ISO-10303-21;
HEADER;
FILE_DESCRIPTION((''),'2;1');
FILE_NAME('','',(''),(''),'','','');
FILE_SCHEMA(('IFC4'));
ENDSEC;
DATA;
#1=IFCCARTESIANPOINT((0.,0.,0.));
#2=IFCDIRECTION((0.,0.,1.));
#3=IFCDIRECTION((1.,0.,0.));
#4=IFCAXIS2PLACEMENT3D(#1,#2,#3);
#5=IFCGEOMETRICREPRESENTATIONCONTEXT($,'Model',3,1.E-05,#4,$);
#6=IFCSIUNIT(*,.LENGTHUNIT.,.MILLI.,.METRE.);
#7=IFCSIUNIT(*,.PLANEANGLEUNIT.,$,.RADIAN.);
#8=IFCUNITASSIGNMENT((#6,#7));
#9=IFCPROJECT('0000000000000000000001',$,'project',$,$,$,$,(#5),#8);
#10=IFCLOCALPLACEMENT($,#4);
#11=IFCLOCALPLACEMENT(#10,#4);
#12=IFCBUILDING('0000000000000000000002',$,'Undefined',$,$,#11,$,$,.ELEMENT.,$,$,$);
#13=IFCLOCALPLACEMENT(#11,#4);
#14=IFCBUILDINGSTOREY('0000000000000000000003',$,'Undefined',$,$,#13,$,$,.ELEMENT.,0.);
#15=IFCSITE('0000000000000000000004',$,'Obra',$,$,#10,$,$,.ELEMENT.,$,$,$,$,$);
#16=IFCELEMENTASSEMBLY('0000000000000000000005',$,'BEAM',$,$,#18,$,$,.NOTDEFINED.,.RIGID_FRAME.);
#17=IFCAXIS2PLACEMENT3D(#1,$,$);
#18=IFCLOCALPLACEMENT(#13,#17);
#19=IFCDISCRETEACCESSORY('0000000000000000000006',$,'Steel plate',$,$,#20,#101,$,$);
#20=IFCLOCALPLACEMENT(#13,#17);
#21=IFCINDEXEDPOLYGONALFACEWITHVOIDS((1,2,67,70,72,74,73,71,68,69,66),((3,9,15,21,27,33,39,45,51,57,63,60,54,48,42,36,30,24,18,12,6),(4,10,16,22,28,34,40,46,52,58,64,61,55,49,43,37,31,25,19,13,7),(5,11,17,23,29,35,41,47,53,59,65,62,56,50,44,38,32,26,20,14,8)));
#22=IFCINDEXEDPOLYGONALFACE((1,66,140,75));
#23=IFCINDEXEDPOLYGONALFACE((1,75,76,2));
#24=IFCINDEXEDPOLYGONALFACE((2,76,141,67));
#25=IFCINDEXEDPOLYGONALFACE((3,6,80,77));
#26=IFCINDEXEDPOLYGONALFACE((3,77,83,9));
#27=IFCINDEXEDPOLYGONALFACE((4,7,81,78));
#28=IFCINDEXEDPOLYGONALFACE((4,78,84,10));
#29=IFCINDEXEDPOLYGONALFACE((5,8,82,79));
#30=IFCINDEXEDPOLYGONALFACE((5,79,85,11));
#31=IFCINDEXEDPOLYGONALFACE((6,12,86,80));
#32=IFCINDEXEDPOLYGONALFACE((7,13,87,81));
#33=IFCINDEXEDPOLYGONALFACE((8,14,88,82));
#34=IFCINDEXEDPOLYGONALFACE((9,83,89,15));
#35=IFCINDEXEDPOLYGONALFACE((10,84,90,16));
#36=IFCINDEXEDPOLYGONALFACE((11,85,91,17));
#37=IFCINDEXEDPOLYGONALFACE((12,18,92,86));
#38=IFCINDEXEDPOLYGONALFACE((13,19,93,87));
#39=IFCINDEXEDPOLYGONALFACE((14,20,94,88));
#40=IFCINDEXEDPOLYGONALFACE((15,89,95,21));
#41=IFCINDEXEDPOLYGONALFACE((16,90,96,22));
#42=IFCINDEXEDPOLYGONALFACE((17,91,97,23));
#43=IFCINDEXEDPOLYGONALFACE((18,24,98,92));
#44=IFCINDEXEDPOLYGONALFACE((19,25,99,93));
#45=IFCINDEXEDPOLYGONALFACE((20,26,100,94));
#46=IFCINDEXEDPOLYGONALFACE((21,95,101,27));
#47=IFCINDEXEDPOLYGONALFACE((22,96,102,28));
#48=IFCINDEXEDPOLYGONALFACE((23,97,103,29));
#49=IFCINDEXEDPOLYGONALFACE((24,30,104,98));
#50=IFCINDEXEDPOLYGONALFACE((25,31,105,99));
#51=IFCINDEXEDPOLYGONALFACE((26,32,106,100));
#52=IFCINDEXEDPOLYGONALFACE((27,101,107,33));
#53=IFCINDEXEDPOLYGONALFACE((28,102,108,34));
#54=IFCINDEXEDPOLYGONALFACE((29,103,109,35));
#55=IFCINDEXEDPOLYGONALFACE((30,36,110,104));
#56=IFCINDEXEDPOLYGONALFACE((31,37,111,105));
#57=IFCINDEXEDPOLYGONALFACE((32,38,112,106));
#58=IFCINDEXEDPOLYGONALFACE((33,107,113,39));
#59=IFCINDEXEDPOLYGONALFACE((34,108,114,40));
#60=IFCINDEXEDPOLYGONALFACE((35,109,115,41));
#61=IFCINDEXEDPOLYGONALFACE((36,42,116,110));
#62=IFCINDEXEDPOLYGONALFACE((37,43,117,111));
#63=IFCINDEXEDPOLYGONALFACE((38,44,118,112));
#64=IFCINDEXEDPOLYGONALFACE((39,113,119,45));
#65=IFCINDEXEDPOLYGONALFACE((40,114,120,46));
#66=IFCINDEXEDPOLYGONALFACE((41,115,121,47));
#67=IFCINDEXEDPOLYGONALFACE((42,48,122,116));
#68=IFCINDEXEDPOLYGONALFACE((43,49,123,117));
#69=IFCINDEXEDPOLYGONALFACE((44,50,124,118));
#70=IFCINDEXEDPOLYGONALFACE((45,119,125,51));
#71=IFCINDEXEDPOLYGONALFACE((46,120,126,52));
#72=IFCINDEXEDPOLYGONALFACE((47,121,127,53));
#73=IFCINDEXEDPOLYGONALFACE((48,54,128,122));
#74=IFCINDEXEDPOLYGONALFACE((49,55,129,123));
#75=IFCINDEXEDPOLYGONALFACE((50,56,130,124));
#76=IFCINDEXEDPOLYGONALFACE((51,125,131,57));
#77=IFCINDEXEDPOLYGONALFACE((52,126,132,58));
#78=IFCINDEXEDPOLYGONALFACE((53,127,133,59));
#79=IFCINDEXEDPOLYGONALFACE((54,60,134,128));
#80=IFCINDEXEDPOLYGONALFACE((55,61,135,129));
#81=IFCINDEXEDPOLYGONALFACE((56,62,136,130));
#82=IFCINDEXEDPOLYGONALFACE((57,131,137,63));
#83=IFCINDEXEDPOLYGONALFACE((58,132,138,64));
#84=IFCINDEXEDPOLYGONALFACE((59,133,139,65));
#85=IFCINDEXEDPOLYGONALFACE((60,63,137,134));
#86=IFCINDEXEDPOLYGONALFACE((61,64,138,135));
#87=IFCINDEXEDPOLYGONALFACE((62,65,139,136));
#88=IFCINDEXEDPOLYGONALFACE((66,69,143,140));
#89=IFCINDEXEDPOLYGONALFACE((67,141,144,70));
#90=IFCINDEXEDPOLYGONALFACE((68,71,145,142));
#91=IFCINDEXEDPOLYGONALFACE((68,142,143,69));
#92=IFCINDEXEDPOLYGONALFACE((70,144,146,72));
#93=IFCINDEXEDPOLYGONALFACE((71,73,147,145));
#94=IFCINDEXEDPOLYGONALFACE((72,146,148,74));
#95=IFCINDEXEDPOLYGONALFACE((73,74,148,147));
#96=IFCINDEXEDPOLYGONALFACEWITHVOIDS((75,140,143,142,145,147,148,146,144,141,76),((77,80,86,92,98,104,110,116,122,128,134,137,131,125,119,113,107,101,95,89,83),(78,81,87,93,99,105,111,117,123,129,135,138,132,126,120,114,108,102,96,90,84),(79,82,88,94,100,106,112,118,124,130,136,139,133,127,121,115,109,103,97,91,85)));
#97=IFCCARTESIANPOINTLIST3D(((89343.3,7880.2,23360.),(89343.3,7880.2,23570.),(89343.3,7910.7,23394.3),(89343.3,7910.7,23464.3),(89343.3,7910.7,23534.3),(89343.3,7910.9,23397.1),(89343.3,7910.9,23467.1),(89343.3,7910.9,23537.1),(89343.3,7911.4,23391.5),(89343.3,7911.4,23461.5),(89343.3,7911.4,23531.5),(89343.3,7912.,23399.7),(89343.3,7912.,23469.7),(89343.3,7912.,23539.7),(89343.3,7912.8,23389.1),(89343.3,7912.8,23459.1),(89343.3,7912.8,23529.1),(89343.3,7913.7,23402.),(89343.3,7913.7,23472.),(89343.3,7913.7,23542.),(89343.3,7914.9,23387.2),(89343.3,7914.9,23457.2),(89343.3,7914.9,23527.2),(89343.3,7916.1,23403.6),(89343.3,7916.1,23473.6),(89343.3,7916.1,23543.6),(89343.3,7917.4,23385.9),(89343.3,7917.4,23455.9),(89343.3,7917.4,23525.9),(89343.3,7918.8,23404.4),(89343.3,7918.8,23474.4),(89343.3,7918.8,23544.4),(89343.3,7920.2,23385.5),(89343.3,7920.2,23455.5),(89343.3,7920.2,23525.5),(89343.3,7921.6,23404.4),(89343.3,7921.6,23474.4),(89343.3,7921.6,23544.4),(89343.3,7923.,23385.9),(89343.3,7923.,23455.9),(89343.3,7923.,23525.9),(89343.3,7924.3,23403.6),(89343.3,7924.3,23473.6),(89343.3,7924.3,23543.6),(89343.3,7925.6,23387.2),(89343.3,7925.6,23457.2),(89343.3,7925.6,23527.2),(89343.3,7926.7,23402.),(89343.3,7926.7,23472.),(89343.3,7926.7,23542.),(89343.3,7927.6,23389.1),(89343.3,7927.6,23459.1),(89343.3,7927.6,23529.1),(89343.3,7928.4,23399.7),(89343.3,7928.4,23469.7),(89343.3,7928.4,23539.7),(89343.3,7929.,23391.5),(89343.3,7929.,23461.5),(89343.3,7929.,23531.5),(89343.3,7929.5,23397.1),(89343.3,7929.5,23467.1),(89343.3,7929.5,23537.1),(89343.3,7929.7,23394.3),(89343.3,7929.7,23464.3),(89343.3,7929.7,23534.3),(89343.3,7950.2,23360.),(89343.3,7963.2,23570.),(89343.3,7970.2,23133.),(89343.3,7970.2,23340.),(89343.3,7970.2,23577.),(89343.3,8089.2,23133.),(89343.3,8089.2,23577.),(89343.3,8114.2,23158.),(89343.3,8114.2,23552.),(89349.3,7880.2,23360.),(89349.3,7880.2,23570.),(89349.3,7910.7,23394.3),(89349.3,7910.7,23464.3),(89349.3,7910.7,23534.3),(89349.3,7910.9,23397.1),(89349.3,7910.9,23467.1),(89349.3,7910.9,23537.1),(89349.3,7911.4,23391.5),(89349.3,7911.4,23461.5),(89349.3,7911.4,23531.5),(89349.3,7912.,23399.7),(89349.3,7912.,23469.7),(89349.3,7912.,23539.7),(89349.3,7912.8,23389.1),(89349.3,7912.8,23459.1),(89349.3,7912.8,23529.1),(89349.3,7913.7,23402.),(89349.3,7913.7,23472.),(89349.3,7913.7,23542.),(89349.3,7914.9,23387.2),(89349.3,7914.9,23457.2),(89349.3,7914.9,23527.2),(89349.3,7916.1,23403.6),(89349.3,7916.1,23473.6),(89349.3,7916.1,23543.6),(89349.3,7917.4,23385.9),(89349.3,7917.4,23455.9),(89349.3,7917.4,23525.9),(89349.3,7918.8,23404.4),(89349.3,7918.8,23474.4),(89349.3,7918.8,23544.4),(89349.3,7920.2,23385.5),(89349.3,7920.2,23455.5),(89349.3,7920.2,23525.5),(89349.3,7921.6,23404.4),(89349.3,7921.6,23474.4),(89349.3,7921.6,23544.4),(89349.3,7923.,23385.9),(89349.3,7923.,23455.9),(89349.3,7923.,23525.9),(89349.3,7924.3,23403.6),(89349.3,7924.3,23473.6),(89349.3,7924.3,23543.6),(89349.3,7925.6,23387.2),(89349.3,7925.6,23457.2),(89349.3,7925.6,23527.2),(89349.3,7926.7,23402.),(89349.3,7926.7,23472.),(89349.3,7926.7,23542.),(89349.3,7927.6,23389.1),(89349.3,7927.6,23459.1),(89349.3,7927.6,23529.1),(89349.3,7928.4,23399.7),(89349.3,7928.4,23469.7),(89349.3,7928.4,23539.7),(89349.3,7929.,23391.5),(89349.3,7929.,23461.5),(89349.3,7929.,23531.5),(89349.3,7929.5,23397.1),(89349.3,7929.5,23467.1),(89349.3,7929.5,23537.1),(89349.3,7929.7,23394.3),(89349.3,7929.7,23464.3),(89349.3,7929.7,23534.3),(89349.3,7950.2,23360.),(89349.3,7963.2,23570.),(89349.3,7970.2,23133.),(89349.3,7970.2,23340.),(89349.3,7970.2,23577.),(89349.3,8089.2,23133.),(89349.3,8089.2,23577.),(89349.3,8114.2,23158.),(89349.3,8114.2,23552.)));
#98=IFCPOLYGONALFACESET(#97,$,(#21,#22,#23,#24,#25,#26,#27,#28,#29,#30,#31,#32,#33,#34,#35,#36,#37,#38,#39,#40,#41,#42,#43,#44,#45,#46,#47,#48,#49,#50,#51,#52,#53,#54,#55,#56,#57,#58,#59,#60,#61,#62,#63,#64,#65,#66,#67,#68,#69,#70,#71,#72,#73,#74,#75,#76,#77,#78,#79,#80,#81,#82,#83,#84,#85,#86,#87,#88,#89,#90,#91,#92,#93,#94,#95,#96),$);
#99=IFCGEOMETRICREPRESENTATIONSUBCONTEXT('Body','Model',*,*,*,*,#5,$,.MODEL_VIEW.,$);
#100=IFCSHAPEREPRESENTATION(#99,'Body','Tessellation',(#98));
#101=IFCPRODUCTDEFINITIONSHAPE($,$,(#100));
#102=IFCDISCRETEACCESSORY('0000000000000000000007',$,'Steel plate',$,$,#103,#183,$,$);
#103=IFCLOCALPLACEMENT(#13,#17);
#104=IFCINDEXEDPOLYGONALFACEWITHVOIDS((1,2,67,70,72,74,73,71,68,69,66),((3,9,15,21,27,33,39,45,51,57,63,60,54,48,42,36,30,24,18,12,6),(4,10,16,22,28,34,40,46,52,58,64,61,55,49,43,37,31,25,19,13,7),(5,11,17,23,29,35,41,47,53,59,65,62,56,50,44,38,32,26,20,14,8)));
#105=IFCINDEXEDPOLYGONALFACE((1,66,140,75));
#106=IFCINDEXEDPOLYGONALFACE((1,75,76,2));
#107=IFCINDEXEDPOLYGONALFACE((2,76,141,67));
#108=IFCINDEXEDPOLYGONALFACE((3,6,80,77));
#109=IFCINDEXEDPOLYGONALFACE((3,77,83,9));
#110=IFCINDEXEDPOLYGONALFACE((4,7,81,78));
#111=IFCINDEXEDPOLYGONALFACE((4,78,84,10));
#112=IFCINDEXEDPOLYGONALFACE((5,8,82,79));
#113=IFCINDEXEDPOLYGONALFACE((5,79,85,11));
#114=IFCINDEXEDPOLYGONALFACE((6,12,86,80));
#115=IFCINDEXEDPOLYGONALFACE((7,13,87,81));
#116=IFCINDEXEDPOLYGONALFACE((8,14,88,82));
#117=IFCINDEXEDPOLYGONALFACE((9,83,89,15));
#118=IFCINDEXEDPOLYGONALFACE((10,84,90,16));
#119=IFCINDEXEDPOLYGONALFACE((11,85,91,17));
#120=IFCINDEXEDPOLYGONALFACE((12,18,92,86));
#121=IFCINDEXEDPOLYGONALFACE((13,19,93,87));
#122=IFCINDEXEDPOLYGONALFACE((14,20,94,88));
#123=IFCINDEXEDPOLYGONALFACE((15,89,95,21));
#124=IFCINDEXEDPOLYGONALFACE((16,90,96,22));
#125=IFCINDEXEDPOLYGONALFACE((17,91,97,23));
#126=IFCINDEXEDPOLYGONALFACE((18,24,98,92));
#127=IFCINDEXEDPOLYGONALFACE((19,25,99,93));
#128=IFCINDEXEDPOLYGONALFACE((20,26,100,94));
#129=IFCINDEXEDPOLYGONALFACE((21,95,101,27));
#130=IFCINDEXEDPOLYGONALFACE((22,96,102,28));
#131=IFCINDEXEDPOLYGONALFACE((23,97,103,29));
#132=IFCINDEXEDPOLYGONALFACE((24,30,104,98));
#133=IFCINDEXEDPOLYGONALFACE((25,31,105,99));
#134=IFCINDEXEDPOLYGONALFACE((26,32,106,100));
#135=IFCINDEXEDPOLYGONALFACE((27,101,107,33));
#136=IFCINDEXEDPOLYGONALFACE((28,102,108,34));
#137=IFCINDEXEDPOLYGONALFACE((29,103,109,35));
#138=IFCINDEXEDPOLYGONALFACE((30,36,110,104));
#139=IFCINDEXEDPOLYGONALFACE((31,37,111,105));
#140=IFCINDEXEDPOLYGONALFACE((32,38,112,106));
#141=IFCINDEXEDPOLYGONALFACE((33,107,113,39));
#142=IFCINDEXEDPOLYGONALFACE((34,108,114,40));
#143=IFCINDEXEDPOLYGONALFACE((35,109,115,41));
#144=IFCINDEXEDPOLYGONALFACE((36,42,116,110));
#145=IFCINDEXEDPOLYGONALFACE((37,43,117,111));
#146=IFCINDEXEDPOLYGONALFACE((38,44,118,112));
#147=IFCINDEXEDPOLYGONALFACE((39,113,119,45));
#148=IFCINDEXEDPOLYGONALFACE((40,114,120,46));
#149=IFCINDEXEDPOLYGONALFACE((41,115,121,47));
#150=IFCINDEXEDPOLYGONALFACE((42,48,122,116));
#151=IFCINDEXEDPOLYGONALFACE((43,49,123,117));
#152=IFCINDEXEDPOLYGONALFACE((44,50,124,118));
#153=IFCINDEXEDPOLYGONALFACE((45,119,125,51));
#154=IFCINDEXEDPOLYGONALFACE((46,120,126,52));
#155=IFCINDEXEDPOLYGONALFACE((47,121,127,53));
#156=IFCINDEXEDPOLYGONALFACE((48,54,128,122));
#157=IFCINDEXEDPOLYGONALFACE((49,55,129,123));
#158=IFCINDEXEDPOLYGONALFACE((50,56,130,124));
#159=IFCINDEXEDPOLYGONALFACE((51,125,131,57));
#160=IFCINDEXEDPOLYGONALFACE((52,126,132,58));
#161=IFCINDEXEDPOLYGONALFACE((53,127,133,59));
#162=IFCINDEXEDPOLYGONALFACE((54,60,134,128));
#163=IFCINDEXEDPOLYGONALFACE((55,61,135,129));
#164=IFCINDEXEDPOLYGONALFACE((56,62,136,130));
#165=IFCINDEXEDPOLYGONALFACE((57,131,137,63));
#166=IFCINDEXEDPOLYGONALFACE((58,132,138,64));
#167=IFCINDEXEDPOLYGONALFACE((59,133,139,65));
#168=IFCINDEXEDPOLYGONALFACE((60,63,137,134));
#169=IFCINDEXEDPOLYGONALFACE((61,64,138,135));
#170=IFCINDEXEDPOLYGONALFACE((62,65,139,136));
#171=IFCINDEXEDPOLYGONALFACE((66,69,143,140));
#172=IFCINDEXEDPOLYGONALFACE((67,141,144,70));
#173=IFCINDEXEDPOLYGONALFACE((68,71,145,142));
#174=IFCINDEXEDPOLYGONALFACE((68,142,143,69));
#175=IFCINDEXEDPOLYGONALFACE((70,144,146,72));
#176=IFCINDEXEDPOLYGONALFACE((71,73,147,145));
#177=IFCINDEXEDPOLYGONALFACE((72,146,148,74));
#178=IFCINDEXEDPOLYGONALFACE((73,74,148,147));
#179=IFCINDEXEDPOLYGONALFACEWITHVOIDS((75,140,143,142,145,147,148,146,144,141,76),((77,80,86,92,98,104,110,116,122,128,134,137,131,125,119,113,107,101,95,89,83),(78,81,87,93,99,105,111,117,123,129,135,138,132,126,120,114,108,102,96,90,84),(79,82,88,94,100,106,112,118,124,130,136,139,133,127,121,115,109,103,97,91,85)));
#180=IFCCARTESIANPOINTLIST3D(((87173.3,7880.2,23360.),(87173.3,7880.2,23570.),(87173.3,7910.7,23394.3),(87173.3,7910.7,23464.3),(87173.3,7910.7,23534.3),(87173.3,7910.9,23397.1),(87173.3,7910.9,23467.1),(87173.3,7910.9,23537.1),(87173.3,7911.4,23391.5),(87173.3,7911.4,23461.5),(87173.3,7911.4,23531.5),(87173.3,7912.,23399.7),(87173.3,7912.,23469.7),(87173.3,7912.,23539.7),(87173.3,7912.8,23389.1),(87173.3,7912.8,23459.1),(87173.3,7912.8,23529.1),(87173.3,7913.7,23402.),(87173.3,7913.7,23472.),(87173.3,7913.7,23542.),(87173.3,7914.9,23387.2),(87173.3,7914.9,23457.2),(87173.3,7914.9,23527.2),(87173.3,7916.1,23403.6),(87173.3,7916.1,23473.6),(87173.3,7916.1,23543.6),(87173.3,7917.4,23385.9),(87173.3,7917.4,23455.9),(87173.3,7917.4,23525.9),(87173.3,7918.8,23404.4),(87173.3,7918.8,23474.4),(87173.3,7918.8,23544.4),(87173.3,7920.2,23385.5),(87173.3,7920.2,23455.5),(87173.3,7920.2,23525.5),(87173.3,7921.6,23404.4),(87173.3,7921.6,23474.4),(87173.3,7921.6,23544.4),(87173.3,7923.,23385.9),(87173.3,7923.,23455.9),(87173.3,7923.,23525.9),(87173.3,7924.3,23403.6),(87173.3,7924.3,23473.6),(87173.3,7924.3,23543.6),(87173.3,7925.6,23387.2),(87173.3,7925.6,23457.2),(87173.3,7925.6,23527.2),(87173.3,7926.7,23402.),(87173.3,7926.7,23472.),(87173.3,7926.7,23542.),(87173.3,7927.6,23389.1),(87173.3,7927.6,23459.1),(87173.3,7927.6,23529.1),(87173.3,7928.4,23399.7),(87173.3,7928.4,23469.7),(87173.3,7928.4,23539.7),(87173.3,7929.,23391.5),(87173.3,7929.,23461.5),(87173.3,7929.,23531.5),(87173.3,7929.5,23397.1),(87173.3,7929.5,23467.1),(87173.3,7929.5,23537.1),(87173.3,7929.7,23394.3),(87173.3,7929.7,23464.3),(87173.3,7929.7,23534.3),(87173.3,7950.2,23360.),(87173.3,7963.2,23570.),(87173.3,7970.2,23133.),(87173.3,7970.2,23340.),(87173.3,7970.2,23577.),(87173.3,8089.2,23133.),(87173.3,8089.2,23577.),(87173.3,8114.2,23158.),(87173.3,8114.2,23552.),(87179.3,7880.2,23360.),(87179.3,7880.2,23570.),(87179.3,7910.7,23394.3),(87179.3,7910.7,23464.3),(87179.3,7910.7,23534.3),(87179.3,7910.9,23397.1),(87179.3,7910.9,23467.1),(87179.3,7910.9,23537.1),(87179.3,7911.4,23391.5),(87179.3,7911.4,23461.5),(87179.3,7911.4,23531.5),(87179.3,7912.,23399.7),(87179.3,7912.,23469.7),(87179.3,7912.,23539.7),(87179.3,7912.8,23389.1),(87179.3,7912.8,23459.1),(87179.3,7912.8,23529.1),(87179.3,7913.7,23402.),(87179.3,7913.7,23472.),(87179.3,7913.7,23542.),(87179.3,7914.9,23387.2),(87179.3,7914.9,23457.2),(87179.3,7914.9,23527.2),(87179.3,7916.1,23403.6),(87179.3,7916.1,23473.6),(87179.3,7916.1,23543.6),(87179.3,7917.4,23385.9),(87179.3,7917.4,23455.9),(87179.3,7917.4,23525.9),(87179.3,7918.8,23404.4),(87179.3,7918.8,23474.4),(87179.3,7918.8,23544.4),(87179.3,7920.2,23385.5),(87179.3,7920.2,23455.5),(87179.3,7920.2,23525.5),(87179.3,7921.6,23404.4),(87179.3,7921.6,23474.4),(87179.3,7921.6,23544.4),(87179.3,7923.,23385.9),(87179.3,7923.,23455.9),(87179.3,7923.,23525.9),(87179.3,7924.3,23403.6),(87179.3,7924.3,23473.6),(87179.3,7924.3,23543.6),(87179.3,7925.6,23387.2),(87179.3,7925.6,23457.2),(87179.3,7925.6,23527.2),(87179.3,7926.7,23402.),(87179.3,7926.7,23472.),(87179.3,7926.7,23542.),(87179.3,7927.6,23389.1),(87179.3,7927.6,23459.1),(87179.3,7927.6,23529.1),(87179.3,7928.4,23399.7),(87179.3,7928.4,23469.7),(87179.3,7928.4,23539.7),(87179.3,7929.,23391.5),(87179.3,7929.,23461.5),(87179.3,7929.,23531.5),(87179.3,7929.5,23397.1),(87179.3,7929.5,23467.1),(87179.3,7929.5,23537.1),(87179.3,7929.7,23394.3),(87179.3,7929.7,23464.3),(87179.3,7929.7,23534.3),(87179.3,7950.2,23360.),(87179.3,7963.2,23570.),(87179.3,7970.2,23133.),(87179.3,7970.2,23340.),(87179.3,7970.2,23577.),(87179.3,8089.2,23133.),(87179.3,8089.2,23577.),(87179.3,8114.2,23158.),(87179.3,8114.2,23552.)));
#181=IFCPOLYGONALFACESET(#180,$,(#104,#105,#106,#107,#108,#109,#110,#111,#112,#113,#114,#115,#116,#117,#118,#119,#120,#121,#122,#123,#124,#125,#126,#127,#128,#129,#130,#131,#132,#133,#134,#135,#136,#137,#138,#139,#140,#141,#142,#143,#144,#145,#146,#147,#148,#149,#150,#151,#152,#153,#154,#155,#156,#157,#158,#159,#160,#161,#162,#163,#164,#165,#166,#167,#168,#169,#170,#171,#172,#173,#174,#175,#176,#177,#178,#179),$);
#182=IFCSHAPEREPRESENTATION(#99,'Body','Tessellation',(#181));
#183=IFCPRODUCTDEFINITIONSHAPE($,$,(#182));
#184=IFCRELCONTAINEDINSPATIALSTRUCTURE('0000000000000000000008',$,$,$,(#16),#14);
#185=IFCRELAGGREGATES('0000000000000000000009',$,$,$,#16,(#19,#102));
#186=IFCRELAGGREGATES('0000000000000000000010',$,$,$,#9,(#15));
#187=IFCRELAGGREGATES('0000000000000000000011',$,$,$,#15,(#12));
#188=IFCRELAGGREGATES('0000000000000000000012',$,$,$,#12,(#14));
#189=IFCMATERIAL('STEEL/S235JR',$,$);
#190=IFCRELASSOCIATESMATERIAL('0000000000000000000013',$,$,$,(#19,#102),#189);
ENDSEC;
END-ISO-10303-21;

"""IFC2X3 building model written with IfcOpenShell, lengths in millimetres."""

from ifc_helpers import new_model, si_unit, frame, origin_with_axes, origin_2d_with_axis, place, context, subcontext, project, spatial, polyline, circle, outline, extrude, source, transform, mapped, material, element, aggregate, save


model = new_model("IFC2X3")

# Units and contexts
model_context = context("Model", 3, precision=1e-05, world=origin_with_axes())
body_context = subcontext(model_context, "Body", "Model", "MODEL_VIEW")
ifc_project = project(units=[si_unit("LENGTHUNIT", "METRE", prefix="MILLI"), si_unit("PLANEANGLEUNIT", "RADIAN")], contexts=[model_context])

# Site, building, storey
site_placement = place(None, origin_with_axes())
site = spatial("IfcSite", under=ifc_project, at=site_placement, Name="Obra", CompositionType="ELEMENT")
building_placement = place(site_placement, origin_with_axes())
building = spatial("IfcBuilding", under=site, at=building_placement, Name="Undefined", CompositionType="ELEMENT")
storey_placement = place(building_placement, origin_with_axes())
storey = spatial("IfcBuildingStorey", under=building, at=storey_placement, Name="Undefined", CompositionType="ELEMENT", Elevation=0.0)

# Shared definitions
ifc_material_1 = material(Name="STEEL/S235JR")

# Element assembly
assembly_1_placement = place(storey_placement, origin_with_axes())
assembly_1 = element("IfcElementAssembly", 1, at=assembly_1_placement, inside=storey, Name="BEAM", AssemblyPlace="NOTDEFINED", PredefinedType="RIGID_FRAME")

# Discrete accessories, openings
discrete_accessory_1_placement = place(assembly_1_placement, frame((89346.3, 8114.2, 23158.0), z_axis=(-1.0, 0.0, 0.0), x_axis=(0.0, -0.707107, -0.707107)))
discrete_accessory_1 = element("IfcDiscreteAccessory", 2, at=discrete_accessory_1_placement, material=ifc_material_1, Name="Steel plate", context=body_context, shape_type="SweptSolid", body=[
    extrude(outline(polyline([(0.0, 0.0), (35.4, 0.0), (119.5, 84.1), (-26.9, 230.5), (-26.9, 258.8), (22.6, 308.3), (-125.9, 456.8), (-184.6, 398.1), (-194.5, 398.1), (-194.5, 398.1), (-278.6, 314.0), (-278.6, 278.6), (0.0, 0.0)])), frame((0.0, 0.0, -3.0), z_axis=(0.0, 0.0, 1.0), x_axis=(1.0, 0.0, 0.0)), (0.0, 0.0, 1.0), 6.0),
])
shared_shape_1 = source(origin_with_axes(), body_context, "Body", "SweptSolid", [
    extrude(circle(Radius=9.5, at=origin_2d_with_axis()), frame((0.0, 3.2, 0.0), z_axis=(0.0, 1.0, 0.0), x_axis=(1.0, 0.0, 0.0)), (0.0, 0.0, 1.0), 6.2),
])
opening_1_placement = place(assembly_1_placement, frame((89340.0, 7960.2, 23570.0), z_axis=(0.0, -1.0, 0.0), x_axis=(0.0, 0.0, -1.0)))
element("IfcOpeningElement", 3, at=opening_1_placement, cuts=discrete_accessory_1, ObjectType="Opening", context=body_context, shape_type="MappedRepresentation", body=[
    mapped(shared_shape_1, transform((35.0, 0.0, 40.0))),
    mapped(shared_shape_1, transform((105.0, 0.0, 40.0))),
    mapped(shared_shape_1, transform((175.0, 0.0, 40.0))),
])
discrete_accessory_2_placement = place(assembly_1_placement, frame((87176.3, 8114.2, 23158.0), z_axis=(-1.0, 0.0, 0.0), x_axis=(0.0, -0.707107, -0.707107)))
discrete_accessory_2 = element("IfcDiscreteAccessory", 4, at=discrete_accessory_2_placement, material=ifc_material_1, Name="Steel plate", context=body_context, shape_type="SweptSolid", body=[
    extrude(outline(polyline([(0.0, 0.0), (35.4, 0.0), (119.5, 84.1), (-26.9, 230.5), (-26.9, 258.8), (22.6, 308.3), (-125.9, 456.8), (-184.6, 398.1), (-194.5, 398.1), (-194.5, 398.1), (-278.6, 314.0), (-278.6, 278.6), (0.0, 0.0)])), frame((0.0, 0.0, -3.0), z_axis=(0.0, 0.0, 1.0), x_axis=(1.0, 0.0, 0.0)), (0.0, 0.0, 1.0), 6.0),
])
opening_2_placement = place(assembly_1_placement, frame((87170.0, 7960.2, 23570.0), z_axis=(0.0, -1.0, 0.0), x_axis=(0.0, 0.0, -1.0)))
element("IfcOpeningElement", 5, at=opening_2_placement, cuts=discrete_accessory_2, ObjectType="Opening", context=body_context, shape_type="MappedRepresentation", body=[
    mapped(shared_shape_1, transform((35.0, 0.0, 40.0))),
    mapped(shared_shape_1, transform((105.0, 0.0, 40.0))),
    mapped(shared_shape_1, transform((175.0, 0.0, 40.0))),
])
aggregate(assembly_1, [discrete_accessory_1, discrete_accessory_2])

save(model, "model.ifc")
